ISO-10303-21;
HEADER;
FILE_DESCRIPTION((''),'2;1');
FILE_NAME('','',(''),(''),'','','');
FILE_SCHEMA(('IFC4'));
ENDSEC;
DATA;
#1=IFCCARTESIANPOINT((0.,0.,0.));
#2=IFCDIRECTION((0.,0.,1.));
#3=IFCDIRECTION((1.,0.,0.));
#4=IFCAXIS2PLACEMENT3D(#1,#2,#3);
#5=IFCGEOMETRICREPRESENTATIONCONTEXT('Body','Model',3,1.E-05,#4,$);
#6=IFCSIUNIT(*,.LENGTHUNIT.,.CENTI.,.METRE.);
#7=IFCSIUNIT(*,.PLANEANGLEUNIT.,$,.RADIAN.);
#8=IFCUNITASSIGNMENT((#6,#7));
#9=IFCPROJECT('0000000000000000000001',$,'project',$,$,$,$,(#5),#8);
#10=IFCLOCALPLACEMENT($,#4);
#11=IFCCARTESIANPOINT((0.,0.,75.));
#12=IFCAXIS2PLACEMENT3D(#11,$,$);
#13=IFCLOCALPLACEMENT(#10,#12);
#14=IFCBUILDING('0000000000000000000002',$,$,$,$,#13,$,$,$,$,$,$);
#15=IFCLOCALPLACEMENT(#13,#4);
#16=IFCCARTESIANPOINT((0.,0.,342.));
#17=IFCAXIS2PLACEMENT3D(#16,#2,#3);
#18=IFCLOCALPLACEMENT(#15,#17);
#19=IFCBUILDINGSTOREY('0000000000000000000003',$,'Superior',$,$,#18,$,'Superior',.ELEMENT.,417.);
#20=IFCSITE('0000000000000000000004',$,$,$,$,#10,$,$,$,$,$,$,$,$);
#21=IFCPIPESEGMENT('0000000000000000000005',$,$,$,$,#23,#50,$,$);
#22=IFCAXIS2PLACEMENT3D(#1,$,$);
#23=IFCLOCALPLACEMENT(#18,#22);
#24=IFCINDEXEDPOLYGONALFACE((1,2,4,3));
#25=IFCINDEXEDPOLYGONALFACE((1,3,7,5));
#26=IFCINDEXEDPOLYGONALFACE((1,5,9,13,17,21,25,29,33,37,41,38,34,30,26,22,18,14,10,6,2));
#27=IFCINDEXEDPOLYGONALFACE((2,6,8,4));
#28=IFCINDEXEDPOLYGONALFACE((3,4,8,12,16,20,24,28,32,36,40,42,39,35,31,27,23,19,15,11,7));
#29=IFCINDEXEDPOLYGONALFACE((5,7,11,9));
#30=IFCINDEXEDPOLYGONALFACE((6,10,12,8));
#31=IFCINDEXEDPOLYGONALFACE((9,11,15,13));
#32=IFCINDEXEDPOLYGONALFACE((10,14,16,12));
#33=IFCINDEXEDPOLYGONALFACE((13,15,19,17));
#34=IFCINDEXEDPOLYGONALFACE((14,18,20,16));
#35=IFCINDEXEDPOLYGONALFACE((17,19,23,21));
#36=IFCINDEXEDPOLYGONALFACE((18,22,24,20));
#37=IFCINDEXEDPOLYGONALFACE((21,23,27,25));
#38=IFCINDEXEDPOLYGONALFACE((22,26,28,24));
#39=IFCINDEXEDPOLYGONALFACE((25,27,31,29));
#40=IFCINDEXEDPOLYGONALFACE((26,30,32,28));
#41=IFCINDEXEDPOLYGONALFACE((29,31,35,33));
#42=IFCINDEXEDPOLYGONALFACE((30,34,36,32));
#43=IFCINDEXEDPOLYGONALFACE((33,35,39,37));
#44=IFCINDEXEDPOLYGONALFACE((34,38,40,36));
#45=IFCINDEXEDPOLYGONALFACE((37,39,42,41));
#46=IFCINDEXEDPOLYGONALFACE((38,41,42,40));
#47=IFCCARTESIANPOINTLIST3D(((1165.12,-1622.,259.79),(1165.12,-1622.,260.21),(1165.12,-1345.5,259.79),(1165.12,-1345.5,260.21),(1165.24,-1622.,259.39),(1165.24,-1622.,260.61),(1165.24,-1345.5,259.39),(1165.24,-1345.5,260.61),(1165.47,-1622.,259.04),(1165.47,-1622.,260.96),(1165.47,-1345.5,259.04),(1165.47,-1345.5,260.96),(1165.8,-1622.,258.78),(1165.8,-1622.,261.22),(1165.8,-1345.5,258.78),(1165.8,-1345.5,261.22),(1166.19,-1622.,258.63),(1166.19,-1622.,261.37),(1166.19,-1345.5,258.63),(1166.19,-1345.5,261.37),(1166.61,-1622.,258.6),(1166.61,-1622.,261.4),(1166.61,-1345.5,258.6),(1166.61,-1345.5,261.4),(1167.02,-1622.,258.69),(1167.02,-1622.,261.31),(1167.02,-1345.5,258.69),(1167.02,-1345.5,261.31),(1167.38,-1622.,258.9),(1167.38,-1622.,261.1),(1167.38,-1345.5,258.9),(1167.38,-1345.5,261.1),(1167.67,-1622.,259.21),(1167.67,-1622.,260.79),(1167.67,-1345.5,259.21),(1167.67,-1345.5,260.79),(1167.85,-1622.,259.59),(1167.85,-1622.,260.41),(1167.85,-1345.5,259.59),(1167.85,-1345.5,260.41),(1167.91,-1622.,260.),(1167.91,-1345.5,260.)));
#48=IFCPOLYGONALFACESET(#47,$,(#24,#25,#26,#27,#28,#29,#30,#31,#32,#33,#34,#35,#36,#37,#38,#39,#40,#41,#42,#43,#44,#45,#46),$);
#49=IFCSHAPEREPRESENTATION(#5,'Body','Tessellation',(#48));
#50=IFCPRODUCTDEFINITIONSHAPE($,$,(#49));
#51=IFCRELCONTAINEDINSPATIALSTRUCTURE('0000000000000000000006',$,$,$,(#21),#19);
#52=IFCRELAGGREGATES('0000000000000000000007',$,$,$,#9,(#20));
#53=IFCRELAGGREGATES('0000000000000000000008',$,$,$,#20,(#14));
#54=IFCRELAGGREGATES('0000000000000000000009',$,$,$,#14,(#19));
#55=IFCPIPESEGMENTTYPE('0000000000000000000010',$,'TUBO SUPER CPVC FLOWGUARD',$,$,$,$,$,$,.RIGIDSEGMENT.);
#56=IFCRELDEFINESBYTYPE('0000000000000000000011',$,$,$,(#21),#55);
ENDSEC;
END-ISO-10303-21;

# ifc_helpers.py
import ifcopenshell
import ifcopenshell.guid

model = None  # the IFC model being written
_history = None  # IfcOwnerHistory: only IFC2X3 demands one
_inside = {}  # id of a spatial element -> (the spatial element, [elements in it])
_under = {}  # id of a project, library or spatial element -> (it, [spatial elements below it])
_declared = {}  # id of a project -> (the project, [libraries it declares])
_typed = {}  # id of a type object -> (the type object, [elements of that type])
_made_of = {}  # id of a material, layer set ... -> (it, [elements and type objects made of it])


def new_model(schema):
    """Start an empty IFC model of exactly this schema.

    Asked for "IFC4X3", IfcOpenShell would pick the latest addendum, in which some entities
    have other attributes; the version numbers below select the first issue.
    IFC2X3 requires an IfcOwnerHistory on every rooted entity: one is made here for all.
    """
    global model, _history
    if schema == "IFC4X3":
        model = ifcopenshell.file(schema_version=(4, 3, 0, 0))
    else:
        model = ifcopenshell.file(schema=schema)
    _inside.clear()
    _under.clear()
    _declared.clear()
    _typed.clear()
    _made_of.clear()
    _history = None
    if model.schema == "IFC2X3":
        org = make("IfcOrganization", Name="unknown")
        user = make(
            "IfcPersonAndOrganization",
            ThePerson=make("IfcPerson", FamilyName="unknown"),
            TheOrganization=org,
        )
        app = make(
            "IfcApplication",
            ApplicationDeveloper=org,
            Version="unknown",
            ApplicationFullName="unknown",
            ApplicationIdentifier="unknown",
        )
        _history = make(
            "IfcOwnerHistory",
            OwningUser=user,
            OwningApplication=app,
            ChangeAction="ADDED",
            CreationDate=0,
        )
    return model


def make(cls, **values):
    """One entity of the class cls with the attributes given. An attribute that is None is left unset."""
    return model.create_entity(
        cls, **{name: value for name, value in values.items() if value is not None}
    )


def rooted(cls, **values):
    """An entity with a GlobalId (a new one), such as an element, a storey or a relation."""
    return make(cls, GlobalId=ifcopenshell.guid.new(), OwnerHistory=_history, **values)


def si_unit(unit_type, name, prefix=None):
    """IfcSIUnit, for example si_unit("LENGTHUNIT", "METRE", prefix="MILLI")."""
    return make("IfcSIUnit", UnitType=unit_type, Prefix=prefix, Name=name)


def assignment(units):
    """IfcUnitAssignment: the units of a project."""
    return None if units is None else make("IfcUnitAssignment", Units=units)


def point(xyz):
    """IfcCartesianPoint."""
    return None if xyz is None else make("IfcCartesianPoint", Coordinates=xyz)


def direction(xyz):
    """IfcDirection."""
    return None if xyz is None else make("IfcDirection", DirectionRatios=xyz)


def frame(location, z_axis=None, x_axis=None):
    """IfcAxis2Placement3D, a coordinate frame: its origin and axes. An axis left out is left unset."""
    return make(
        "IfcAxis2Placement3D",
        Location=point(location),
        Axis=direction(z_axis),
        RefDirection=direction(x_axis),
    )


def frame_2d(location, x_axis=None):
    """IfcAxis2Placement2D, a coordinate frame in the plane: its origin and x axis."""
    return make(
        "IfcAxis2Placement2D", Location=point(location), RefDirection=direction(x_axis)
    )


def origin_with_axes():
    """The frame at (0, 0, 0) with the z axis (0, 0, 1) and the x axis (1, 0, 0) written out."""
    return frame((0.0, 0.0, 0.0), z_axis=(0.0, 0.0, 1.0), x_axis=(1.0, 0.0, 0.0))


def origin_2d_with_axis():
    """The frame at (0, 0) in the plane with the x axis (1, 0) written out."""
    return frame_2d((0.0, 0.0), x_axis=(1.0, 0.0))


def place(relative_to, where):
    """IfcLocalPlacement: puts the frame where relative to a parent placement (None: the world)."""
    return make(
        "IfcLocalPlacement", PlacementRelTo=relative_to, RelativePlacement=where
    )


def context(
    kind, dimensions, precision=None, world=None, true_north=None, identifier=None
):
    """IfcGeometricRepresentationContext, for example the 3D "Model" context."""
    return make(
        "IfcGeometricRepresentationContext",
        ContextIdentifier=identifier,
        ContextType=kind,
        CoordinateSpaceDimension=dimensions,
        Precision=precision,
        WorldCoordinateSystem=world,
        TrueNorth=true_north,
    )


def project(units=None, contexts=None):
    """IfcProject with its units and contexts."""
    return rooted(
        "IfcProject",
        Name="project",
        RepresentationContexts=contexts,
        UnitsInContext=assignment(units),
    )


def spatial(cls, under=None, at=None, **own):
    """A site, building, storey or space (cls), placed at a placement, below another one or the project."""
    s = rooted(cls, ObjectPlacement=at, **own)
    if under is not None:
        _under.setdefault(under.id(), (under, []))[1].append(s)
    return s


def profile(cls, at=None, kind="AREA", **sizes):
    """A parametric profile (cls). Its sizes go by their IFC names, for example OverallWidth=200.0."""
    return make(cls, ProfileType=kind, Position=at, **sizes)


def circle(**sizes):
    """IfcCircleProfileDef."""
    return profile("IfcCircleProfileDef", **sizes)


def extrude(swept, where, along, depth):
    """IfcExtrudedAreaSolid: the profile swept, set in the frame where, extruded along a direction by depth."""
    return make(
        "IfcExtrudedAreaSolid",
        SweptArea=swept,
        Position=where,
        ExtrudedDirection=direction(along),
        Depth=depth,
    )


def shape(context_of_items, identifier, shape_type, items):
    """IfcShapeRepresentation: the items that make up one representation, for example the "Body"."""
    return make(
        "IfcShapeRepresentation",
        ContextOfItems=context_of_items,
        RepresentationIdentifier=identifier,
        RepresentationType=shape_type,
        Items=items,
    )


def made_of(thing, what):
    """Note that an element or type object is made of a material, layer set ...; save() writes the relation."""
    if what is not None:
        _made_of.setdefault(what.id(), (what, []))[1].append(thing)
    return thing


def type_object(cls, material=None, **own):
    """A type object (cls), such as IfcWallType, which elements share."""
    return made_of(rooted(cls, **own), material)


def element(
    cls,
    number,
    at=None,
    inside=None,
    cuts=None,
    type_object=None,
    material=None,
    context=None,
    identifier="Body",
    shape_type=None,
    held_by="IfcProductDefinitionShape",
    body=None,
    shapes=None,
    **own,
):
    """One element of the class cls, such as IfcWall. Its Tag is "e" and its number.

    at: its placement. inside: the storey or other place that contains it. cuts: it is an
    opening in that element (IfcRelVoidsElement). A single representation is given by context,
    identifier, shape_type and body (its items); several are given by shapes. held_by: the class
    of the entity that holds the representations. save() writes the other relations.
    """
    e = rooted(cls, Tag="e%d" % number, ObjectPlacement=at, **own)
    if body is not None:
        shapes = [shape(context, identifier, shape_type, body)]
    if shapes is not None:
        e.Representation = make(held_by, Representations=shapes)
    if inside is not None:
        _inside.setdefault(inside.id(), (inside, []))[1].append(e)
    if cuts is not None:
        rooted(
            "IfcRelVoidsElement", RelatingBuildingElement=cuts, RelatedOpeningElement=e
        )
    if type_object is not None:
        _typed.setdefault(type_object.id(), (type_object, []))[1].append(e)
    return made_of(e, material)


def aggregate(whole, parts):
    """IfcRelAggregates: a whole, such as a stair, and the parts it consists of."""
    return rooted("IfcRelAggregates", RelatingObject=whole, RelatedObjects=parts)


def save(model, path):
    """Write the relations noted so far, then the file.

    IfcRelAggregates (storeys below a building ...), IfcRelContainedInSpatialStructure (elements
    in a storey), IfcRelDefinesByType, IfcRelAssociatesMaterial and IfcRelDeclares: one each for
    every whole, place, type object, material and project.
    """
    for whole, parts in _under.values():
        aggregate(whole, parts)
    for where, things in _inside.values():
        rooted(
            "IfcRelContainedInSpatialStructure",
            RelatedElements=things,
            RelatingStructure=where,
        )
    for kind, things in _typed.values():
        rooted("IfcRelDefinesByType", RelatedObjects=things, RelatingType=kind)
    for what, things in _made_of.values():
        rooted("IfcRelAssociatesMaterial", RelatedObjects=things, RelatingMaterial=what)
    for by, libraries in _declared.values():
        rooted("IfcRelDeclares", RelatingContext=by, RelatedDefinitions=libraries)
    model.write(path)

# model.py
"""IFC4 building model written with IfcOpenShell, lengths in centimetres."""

from ifc_helpers import new_model, si_unit, frame, origin_with_axes, origin_2d_with_axis, place, context, project, spatial, circle, extrude, type_object, element, save


model = new_model("IFC4")

# Units and contexts
model_context = context("Model", 3, precision=1e-05, world=origin_with_axes(), identifier="Body")
ifc_project = project(units=[si_unit("LENGTHUNIT", "METRE", prefix="CENTI"), si_unit("PLANEANGLEUNIT", "RADIAN")], contexts=[model_context])

# Site, building, storey
site_placement = place(None, origin_with_axes())
site = spatial("IfcSite", under=ifc_project, at=site_placement)
building_placement = place(site_placement, frame((0.0, 0.0, 75.0)))
building = spatial("IfcBuilding", under=site, at=building_placement)
placement = place(building_placement, origin_with_axes())
storey_placement = place(placement, frame((0.0, 0.0, 342.0), z_axis=(0.0, 0.0, 1.0), x_axis=(1.0, 0.0, 0.0)))
storey = spatial("IfcBuildingStorey", under=building, at=storey_placement, Name="Superior", LongName="Superior", CompositionType="ELEMENT", Elevation=417.0)

# Pipe segment
pipe_segment_type_1 = type_object("IfcPipeSegmentType", Name="TUBO SUPER CPVC FLOWGUARD", PredefinedType="RIGIDSEGMENT")
pipe_segment_1_placement = place(storey_placement, frame((1166.5, -1483.75, 261.4), z_axis=(0.0, 0.0, 1.0), x_axis=(1.0, 0.0, 0.0)))
element("IfcPipeSegment", 1, at=pipe_segment_1_placement, inside=storey, type_object=pipe_segment_type_1, context=model_context, shape_type="SolidModel", body=[
    extrude(circle(Radius=1.41, at=origin_2d_with_axis()), frame((0.0, 138.25, -1.41), z_axis=(0.0, -1.0, 0.0), x_axis=(1.0, 0.0, 0.0)), (0.0, 0.0, 1.0), 276.5),
])

save(model, "model.ifc")
